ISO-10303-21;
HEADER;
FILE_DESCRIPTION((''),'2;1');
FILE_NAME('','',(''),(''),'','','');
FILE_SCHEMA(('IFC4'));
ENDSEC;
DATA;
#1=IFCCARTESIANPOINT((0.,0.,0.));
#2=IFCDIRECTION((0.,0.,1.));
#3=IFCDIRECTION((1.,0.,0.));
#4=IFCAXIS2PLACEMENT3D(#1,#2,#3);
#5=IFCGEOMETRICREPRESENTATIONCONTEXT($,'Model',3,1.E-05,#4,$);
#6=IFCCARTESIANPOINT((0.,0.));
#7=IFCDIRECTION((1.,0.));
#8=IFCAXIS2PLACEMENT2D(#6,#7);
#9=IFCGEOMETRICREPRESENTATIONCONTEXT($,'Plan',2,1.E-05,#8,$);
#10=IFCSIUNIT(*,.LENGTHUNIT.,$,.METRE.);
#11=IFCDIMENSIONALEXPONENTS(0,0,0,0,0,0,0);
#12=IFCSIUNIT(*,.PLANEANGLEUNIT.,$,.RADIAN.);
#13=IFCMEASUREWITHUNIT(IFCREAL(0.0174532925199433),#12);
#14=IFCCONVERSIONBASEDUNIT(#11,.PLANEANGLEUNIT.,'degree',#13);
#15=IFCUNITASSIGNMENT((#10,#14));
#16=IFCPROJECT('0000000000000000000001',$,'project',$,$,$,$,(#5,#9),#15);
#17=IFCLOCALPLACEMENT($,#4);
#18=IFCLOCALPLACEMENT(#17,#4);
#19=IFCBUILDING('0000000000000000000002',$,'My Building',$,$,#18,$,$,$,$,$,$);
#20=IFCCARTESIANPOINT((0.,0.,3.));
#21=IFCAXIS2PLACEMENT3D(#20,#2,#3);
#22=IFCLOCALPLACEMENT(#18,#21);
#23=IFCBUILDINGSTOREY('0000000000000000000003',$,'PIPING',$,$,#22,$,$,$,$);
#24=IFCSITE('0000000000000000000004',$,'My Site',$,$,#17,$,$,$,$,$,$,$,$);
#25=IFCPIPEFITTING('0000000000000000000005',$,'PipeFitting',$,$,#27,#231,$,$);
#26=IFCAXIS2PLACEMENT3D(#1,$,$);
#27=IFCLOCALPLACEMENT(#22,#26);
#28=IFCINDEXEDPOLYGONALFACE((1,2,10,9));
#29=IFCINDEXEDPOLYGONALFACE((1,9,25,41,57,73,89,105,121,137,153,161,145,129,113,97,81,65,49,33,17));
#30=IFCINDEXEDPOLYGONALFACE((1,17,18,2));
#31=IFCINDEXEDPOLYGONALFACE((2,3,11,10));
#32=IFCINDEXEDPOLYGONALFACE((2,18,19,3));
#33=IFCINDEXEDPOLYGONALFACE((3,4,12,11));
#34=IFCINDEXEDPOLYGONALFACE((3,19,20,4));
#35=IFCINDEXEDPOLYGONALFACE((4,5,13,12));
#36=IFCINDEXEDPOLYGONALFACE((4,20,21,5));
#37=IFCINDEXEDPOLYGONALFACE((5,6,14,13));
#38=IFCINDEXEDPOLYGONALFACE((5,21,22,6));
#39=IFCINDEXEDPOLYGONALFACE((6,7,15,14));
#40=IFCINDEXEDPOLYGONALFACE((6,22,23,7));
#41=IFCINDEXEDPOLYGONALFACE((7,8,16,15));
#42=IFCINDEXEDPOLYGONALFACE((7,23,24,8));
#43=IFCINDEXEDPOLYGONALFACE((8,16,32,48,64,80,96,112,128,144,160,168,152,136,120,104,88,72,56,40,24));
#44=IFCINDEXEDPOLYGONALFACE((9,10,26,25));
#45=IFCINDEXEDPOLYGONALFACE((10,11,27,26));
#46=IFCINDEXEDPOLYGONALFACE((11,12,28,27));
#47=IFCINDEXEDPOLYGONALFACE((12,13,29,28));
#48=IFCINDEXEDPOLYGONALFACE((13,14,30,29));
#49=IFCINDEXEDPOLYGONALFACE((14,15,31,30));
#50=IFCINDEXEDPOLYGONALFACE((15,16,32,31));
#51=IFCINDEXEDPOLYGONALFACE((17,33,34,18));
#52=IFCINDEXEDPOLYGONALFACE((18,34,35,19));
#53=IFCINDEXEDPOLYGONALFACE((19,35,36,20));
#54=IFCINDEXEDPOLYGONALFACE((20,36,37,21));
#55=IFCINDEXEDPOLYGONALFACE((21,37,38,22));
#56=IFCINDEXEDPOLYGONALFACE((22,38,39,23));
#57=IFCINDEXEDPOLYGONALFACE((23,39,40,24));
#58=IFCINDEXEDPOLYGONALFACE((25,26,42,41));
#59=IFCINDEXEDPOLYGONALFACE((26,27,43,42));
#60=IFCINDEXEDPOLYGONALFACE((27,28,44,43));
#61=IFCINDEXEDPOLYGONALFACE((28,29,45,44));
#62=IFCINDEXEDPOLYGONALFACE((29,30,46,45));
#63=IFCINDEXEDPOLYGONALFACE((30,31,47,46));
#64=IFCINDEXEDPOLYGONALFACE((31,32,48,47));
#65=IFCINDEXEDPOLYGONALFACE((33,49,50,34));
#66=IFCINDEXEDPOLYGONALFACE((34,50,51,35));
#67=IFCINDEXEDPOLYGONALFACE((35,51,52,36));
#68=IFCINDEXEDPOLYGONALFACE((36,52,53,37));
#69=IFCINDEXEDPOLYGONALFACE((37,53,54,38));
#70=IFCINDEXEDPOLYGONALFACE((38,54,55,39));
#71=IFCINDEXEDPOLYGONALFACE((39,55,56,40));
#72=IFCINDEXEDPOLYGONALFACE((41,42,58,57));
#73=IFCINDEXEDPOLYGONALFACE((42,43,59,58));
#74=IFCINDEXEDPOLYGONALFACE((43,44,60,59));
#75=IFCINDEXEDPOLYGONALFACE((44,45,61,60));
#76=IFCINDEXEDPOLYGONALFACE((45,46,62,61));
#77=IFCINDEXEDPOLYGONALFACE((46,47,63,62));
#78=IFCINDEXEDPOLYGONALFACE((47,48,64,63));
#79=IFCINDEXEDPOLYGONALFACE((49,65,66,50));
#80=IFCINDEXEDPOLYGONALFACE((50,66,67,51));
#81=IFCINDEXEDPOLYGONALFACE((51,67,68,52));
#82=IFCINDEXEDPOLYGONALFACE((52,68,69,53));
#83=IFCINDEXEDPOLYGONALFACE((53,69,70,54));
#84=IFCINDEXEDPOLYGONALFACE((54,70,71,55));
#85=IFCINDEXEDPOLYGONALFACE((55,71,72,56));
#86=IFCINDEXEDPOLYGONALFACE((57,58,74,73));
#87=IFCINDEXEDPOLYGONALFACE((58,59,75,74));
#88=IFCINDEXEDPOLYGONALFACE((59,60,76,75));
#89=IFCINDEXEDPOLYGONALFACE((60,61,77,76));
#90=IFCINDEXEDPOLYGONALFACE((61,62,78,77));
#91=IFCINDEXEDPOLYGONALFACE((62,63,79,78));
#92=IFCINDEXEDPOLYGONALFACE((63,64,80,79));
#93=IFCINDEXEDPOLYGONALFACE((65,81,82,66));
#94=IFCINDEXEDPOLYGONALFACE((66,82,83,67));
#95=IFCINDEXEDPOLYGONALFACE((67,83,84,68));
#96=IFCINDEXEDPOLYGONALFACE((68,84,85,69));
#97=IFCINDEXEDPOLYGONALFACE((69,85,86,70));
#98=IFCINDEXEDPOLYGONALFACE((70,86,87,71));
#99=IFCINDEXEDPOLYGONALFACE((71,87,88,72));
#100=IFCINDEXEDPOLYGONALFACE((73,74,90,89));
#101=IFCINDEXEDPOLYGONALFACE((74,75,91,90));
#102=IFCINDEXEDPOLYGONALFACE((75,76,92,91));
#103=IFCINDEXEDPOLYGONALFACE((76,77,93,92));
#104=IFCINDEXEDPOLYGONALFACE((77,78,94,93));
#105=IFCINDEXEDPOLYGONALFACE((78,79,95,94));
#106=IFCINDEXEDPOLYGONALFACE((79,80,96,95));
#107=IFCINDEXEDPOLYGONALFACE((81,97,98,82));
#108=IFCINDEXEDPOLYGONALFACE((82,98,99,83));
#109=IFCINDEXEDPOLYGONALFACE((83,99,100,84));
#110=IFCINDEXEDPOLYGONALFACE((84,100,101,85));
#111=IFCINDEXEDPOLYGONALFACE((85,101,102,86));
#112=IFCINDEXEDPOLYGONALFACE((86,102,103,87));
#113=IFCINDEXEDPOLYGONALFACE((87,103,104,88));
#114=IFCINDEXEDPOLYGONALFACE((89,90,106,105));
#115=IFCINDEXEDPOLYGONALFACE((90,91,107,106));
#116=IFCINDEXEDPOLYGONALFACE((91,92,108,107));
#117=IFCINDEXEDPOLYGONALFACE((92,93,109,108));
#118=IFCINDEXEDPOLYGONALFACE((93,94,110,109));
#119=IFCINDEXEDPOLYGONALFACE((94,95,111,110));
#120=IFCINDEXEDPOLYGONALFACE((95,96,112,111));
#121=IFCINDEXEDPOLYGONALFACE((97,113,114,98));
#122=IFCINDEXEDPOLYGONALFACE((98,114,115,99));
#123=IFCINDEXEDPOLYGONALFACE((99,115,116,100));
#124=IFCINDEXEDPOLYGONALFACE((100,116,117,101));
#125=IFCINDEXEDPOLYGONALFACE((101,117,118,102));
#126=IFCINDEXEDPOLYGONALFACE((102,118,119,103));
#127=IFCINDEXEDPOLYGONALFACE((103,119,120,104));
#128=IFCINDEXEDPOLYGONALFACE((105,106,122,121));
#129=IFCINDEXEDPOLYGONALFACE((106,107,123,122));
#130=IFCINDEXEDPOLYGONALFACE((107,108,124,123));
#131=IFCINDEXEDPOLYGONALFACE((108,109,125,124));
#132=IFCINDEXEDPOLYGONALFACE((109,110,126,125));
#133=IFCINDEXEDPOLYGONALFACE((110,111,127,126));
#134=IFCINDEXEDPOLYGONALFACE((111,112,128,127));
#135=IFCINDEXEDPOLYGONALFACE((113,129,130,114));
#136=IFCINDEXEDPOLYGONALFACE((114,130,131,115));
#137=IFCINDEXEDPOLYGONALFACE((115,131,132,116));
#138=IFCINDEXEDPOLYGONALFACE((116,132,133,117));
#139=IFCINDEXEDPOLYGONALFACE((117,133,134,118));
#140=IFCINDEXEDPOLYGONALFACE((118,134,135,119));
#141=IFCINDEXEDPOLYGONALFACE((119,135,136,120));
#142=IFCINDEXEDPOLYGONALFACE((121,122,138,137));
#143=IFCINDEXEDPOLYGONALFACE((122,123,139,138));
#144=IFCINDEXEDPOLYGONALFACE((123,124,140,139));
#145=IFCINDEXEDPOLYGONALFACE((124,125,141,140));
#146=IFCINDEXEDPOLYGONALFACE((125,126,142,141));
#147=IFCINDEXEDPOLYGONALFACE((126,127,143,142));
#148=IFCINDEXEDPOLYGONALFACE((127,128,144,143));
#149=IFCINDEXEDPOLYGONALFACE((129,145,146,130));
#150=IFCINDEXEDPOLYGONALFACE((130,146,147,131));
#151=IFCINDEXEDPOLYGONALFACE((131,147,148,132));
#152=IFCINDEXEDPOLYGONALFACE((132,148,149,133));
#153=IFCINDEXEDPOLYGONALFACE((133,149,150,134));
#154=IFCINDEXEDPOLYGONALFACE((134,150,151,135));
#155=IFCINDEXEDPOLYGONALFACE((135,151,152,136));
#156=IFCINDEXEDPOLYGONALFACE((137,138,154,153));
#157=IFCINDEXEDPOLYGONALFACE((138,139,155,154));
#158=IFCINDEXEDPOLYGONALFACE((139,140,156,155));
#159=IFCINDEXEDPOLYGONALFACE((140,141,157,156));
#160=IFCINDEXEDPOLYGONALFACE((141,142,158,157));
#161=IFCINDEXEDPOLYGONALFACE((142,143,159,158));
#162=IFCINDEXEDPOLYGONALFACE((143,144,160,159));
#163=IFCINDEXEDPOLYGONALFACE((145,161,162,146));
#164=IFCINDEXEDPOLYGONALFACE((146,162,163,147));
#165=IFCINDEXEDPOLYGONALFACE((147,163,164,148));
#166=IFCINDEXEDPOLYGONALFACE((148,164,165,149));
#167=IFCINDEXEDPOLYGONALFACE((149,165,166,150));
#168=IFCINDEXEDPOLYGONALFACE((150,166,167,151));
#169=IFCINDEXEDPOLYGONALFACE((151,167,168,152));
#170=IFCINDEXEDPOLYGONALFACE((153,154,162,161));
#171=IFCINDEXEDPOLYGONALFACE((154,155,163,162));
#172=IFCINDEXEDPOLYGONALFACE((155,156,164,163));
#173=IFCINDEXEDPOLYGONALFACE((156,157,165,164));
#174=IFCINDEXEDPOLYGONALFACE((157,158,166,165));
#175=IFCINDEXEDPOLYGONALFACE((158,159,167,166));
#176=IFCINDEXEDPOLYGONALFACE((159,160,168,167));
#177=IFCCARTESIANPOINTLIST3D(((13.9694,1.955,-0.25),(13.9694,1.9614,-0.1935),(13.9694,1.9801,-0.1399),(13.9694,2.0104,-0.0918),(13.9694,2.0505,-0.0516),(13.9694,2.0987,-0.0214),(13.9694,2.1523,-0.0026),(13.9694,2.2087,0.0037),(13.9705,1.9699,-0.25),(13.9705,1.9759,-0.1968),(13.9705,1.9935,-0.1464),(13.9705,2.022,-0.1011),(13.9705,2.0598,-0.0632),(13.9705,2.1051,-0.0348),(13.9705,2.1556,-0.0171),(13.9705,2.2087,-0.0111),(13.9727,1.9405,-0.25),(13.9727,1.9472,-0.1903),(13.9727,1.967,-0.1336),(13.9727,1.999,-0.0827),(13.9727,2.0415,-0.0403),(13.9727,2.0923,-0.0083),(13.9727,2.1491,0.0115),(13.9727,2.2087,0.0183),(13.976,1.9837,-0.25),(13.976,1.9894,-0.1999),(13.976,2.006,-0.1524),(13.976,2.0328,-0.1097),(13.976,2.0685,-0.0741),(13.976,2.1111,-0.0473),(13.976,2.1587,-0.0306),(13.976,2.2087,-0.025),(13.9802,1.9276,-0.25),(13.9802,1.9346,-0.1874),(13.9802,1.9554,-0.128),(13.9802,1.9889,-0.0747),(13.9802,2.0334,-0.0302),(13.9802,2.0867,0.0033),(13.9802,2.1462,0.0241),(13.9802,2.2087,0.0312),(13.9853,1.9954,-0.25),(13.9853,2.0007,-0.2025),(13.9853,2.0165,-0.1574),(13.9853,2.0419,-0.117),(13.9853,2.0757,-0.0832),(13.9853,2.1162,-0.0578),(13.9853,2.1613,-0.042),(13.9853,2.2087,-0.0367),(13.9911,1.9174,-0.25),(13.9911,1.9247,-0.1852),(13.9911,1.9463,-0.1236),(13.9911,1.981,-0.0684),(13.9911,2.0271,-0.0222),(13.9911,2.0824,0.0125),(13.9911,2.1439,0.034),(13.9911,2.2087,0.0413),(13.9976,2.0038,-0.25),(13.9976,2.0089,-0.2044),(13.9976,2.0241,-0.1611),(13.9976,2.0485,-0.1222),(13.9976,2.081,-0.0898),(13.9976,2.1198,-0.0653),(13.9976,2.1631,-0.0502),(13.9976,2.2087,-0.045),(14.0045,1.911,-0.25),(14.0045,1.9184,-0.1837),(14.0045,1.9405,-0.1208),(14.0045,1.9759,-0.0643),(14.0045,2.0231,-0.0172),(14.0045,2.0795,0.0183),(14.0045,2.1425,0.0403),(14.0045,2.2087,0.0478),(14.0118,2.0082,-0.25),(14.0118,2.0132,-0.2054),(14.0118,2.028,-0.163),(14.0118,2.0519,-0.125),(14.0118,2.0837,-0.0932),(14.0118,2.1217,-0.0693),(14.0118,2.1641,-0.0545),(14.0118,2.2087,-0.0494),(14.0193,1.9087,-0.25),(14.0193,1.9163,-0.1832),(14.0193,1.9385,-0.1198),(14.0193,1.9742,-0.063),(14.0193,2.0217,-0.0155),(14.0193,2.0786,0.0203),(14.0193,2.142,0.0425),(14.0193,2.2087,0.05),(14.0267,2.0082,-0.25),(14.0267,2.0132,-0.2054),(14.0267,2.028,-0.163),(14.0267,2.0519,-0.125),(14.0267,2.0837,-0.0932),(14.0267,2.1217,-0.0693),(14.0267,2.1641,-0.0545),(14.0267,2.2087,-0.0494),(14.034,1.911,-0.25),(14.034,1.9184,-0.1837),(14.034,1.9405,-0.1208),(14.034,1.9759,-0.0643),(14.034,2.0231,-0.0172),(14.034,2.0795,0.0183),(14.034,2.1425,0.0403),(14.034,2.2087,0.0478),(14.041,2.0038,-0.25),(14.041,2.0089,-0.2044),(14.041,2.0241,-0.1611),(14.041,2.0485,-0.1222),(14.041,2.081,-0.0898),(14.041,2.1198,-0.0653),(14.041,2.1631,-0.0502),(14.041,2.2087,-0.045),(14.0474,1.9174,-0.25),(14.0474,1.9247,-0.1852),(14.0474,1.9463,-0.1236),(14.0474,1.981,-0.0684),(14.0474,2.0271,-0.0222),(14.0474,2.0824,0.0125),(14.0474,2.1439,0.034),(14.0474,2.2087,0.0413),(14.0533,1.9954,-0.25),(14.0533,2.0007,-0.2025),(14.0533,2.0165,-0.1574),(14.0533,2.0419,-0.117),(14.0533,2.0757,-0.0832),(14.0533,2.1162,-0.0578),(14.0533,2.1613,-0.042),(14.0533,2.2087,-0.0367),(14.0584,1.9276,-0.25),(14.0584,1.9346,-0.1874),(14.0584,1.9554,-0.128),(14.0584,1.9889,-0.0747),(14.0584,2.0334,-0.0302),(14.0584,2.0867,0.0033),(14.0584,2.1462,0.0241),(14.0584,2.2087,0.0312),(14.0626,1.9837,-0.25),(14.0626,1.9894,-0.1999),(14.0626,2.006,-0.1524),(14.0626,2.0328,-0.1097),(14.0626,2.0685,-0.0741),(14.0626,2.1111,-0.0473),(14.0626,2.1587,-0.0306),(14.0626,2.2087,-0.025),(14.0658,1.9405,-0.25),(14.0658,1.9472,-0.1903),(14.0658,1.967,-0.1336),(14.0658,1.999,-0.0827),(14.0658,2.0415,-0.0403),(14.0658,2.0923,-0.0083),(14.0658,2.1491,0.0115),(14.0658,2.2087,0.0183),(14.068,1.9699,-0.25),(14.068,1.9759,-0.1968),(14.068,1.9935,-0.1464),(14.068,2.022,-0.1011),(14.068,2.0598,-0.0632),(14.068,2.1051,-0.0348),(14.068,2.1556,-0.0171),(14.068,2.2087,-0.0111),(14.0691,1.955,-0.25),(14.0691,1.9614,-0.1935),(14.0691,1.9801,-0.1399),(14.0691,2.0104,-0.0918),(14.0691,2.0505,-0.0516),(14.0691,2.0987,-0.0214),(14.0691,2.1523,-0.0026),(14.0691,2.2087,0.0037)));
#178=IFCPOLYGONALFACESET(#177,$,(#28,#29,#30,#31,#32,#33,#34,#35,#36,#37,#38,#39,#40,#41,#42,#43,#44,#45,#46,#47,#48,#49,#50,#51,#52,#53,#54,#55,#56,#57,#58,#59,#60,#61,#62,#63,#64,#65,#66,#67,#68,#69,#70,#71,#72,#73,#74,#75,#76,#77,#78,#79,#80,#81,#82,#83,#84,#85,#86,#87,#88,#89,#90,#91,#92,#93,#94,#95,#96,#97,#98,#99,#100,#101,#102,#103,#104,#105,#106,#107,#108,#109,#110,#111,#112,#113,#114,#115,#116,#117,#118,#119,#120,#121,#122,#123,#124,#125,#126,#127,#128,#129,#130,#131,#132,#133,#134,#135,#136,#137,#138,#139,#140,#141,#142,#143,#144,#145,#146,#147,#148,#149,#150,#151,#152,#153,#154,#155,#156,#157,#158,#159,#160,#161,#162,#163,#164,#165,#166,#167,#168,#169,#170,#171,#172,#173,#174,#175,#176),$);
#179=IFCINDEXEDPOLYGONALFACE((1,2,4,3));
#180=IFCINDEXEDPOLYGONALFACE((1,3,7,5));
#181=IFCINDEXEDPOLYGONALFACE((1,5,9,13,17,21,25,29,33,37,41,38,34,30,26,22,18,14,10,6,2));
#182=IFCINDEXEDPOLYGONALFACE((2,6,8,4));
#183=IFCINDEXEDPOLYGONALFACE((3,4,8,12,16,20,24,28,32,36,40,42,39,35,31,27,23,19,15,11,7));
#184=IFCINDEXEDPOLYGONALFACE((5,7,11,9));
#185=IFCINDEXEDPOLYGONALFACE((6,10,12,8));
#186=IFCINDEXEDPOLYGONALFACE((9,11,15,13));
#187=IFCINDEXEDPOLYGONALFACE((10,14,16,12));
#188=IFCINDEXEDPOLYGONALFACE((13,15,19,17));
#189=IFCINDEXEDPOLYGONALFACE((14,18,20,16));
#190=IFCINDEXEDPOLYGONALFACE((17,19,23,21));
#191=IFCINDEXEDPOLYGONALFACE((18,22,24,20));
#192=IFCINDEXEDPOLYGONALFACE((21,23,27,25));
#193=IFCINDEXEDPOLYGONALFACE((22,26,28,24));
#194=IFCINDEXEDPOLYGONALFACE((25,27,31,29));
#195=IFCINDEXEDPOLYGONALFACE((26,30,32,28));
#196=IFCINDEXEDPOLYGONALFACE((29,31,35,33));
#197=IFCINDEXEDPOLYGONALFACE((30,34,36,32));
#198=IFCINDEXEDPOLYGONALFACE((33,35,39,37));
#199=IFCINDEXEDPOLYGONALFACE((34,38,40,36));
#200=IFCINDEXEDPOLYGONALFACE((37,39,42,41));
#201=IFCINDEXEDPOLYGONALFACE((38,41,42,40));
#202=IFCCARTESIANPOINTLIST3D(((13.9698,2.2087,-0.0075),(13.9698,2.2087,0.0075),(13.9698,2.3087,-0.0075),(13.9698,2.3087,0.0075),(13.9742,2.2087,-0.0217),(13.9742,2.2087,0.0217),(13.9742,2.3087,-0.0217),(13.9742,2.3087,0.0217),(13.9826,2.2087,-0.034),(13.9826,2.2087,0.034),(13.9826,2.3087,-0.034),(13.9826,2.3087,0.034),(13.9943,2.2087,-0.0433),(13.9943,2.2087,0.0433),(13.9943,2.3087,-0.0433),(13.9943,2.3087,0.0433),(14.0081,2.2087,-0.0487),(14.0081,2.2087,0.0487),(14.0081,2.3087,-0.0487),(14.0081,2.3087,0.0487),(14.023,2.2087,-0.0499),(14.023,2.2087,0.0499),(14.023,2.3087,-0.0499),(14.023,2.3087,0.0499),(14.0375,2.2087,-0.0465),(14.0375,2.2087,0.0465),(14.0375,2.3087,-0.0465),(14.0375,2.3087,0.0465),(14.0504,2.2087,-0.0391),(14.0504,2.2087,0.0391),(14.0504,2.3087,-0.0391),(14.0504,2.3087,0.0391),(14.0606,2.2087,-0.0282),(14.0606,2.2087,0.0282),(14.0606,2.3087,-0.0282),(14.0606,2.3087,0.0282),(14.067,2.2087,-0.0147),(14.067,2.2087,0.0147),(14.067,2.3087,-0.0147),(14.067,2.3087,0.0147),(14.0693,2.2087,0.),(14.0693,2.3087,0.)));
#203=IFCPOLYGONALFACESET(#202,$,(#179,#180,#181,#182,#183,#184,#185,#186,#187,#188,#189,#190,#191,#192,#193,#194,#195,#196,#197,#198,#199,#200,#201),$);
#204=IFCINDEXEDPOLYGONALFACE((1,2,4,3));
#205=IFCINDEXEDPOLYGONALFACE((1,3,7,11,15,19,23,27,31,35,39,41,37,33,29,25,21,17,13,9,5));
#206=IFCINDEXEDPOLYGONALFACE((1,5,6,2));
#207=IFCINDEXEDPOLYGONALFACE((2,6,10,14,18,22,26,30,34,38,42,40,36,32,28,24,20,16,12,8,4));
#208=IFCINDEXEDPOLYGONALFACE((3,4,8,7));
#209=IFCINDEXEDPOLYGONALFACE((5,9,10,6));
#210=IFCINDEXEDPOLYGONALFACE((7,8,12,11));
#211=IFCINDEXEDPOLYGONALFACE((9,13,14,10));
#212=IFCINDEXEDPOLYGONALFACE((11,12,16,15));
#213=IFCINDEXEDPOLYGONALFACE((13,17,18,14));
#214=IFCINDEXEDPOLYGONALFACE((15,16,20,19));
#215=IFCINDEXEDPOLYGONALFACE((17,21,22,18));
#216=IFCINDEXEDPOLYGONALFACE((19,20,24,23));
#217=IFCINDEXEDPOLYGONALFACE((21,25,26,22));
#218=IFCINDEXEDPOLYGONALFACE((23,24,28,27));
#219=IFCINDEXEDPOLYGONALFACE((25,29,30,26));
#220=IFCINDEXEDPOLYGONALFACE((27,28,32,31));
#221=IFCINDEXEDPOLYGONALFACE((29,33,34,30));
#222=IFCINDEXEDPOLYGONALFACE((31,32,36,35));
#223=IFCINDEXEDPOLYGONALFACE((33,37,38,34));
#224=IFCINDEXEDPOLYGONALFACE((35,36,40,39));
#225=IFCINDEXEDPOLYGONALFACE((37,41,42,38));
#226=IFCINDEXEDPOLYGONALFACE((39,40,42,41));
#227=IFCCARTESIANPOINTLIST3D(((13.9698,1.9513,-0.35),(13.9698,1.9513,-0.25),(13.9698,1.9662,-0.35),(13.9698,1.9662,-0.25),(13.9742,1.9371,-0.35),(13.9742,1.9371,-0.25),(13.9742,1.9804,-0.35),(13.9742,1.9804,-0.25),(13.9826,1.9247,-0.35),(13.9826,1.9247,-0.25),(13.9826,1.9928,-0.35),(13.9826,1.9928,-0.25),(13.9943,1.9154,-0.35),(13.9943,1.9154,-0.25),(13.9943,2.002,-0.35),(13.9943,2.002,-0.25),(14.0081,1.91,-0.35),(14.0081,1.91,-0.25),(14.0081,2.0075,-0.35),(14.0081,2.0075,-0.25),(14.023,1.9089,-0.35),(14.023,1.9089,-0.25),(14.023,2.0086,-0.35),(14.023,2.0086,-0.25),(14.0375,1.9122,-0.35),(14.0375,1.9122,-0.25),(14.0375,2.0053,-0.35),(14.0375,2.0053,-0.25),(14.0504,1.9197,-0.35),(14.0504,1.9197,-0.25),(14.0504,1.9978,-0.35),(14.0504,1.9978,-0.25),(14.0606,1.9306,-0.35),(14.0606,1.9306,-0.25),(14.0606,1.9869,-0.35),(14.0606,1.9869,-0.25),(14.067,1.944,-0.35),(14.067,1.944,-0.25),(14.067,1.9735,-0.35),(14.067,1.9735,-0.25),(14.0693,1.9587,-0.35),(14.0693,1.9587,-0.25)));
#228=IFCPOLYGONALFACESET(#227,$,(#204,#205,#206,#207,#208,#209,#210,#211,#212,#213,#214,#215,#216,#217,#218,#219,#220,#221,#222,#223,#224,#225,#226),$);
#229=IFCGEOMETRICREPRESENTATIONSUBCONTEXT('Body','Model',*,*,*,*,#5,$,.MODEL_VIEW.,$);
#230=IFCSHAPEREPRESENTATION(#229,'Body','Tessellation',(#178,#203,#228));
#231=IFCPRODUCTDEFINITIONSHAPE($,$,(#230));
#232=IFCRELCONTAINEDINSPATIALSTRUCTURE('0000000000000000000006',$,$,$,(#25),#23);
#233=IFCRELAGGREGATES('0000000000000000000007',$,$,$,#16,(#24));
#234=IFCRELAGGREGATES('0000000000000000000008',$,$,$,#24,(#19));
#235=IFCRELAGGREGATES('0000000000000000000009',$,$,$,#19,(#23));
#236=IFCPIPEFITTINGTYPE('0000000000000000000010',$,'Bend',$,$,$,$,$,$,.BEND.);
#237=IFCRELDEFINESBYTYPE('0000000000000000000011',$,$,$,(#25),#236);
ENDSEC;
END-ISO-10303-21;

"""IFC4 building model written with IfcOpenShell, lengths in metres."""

from ifc_helpers import new_model, entity, si_unit, converted_unit, frame, origin_with_axes, origin_2d_with_axis, place, context, subcontext, project, spatial, line, indexed_curve, circle, outline, extrude, source, transform, mapped, type_object, type_shapes, element, save


model = new_model("IFC4")

# Units and contexts
model_context = context("Model", 3, precision=1e-05, world=origin_with_axes())
plan_context = context("Plan", 2, precision=1e-05, world=origin_2d_with_axis())
body_context = subcontext(model_context, "Body", "Model", "MODEL_VIEW")
ifc_project = project(units=[si_unit("LENGTHUNIT", "METRE"), converted_unit("PLANEANGLEUNIT", "degree", entity("IfcReal", 0.0174532925199433), si_unit("PLANEANGLEUNIT", "RADIAN"), dimensions=[0, 0, 0, 0, 0, 0, 0])], contexts=[model_context, plan_context])

# Site, building, storey
site_placement = place(None, origin_with_axes())
site = spatial("IfcSite", under=ifc_project, at=site_placement, Name="My Site")
building_placement = place(site_placement, origin_with_axes())
building = spatial("IfcBuilding", under=site, at=building_placement, Name="My Building")
storey_placement = place(building_placement, frame((0.0, 0.0, 3.0), z_axis=(0.0, 0.0, 1.0), x_axis=(1.0, 0.0, 0.0)))
storey = spatial("IfcBuildingStorey", under=building, at=storey_placement, Name="PIPING")

# Pipe fitting, opening
pipe_fitting_type = type_object("IfcPipeFittingType", Name="Bend", PredefinedType="BEND")
shared_shape = source(origin_with_axes(), body_context, "Body", "SolidModel", [
    entity("IfcSweptDiskSolid", entity("IfcIndexedPolyCurve", entity("IfcCartesianPointList3D", [[0.0, 0.0, 0.1], [0.0, -0.0732, 0.2768], [0.0, -0.25, 0.35]]), [entity("IfcArcIndex", [1, 2, 3])]), 0.05),
    extrude(circle(Radius=0.05), origin_with_axes(), (0.0, 0.0, 1.0), 0.1),
    extrude(circle(Radius=0.05), frame((0.0, -0.25, 0.35), z_axis=(0.0, -1.0, 0.0), x_axis=(1.0, 0.0, 0.0)), (0.0, 0.0, 1.0), 0.1),
])
type_shapes(pipe_fitting_type, [shared_shape])
pipe_fitting_1_placement = place(storey_placement, frame((14.0193, 2.3087, 0.0), z_axis=(0.0, -1.0, 0.0), x_axis=(1.0, 0.0, 0.0)))
pipe_fitting_1 = element("IfcPipeFitting", 1, at=pipe_fitting_1_placement, inside=storey, type_object=pipe_fitting_type, Name="PipeFitting", context=body_context, shape_type="MappedRepresentation", body=[
    mapped(shared_shape, transform((0.0, 0.0, 0.0), x_axis=(1.0, 0.0, 0.0), y_axis=(0.0, 1.0, 0.0), z_axis=(0.0, 0.0, 1.0), scale=1.0)),
])
opening_1_placement = place(pipe_fitting_1_placement, frame((-14.0193, -3.0, 2.3087), z_axis=(0.0, 1.0, 0.0), x_axis=(1.0, 0.0, 0.0)))
element("IfcOpeningElement", 2, at=opening_1_placement, cuts=pipe_fitting_1, PredefinedType="OPENING", context=body_context, shape_type="SweptSolid", body=[
    extrude(outline(indexed_curve([(0.0, 0.0), (0.5, 0.0), (0.5, 0.5), (0.0, 0.5)], segments=[line(1, 2, 3, 4, 1)])), origin_with_axes(), (0.0, 0.0, 1.0), 0.5),
])

save(model, "model.ifc")
